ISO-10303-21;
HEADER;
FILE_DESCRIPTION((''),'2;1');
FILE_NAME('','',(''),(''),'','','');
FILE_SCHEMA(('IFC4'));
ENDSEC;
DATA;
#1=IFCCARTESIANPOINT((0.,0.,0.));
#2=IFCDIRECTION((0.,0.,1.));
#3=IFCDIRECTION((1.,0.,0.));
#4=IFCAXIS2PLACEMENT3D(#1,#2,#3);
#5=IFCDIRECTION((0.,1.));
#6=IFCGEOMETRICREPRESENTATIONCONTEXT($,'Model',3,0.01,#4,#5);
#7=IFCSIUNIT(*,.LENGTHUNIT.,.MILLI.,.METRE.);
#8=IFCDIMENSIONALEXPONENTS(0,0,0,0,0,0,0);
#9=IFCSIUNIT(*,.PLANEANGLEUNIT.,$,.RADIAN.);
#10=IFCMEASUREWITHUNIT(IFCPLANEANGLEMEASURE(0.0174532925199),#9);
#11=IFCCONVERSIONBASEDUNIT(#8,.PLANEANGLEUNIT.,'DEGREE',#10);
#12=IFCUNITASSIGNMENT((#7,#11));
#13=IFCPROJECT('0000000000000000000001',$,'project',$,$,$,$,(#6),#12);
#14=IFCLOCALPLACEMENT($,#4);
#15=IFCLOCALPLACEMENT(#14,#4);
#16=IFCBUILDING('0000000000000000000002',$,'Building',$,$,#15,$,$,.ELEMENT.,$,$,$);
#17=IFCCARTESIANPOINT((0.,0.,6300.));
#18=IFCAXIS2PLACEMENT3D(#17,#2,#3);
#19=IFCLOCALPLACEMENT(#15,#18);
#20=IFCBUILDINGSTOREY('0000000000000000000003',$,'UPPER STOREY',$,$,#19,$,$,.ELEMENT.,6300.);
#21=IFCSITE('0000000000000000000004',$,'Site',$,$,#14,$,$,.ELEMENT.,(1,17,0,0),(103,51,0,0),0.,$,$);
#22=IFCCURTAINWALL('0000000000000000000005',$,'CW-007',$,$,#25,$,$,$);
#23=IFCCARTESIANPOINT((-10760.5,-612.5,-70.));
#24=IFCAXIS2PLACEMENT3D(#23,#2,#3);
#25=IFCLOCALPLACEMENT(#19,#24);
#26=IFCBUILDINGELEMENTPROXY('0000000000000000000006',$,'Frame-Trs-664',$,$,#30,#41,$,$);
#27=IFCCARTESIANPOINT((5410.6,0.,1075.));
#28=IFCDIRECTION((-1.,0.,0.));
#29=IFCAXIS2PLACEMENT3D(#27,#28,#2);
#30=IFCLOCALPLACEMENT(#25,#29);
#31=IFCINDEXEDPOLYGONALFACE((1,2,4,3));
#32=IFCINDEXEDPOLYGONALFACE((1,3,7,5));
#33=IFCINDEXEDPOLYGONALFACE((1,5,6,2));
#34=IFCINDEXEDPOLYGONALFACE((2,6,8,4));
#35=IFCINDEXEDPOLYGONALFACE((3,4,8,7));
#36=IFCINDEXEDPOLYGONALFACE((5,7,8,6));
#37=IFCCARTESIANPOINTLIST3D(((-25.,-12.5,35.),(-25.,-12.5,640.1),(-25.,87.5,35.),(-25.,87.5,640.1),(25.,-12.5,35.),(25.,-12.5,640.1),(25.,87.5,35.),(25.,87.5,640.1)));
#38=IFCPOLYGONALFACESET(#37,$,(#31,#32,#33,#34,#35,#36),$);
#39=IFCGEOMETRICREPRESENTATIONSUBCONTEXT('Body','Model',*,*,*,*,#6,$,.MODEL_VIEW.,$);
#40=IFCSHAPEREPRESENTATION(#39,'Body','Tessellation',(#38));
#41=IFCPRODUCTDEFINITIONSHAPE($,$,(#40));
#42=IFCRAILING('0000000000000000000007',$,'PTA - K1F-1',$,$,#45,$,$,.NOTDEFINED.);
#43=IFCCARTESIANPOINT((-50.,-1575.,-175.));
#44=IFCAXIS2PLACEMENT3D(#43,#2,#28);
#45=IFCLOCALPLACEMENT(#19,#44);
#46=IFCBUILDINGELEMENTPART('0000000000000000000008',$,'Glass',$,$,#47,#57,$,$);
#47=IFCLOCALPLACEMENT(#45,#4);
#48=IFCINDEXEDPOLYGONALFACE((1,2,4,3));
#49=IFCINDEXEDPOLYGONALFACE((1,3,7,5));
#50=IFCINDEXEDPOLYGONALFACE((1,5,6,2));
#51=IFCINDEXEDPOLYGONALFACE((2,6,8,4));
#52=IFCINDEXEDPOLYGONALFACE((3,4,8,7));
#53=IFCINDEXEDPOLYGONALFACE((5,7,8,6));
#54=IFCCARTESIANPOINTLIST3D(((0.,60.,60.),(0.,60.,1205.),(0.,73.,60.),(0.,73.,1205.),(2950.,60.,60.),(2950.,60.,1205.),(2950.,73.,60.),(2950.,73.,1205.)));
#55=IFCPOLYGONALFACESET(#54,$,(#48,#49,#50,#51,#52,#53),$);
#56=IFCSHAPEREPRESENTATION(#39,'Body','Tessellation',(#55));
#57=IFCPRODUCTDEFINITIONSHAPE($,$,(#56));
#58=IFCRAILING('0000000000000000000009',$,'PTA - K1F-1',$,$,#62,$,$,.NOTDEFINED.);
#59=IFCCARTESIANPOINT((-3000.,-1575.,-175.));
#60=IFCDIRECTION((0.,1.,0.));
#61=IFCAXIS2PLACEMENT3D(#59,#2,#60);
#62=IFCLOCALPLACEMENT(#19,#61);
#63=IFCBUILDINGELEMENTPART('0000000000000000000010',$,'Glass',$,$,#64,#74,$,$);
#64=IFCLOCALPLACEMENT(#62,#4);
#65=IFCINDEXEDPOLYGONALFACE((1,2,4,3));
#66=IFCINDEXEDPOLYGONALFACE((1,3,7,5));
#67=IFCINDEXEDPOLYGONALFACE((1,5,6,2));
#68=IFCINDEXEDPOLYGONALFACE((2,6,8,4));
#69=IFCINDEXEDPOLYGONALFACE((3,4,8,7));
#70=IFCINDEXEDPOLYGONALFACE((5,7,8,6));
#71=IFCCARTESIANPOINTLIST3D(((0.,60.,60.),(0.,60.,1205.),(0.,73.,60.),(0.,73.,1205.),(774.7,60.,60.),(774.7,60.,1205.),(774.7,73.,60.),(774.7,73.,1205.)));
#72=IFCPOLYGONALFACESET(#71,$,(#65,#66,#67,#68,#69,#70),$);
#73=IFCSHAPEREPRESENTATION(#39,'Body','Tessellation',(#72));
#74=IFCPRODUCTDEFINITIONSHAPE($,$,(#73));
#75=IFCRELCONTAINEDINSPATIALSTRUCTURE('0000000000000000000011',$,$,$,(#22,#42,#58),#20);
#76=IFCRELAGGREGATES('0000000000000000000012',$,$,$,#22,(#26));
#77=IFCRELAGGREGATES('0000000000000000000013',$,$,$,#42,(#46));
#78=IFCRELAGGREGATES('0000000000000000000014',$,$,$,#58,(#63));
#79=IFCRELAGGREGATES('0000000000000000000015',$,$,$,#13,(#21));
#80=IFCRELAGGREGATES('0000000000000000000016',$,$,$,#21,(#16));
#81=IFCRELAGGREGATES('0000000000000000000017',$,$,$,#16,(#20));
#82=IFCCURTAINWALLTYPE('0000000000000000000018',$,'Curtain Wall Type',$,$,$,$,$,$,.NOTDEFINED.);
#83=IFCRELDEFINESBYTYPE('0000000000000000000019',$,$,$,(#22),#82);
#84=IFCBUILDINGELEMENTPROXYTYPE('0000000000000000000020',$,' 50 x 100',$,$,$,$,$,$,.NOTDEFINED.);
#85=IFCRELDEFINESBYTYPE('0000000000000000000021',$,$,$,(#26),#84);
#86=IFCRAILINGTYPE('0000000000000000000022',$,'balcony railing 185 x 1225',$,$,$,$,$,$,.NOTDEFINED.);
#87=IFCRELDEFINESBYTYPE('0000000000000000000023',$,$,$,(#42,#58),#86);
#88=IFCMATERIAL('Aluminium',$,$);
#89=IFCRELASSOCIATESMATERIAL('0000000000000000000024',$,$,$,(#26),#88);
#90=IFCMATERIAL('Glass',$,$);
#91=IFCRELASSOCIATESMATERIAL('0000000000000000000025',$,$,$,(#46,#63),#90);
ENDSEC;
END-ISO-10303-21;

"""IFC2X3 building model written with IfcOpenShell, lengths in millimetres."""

from ifc_helpers import new_model, entity, si_unit, converted_unit, direction, frame, origin_with_axes, place, context, subcontext, project, spatial, polyline, outline, extrude, material, type_object, element, aggregate, save


model = new_model("IFC2X3")

# Units and contexts
model_context = context("Model", 3, precision=0.01, world=origin_with_axes(), true_north=direction((0.0, 1.0)))
body_context = subcontext(model_context, "Body", "Model", "MODEL_VIEW")
ifc_project = project(units=[si_unit("LENGTHUNIT", "METRE", prefix="MILLI"), converted_unit("PLANEANGLEUNIT", "DEGREE", entity("IfcPlaneAngleMeasure", 0.0174532925199), si_unit("PLANEANGLEUNIT", "RADIAN"), dimensions=[0, 0, 0, 0, 0, 0, 0])], contexts=[model_context])

# Site, building, storey
site_placement = place(None, origin_with_axes())
site = spatial("IfcSite", under=ifc_project, at=site_placement, Name="Site", CompositionType="ELEMENT", RefLatitude=(1, 17, 0, 0), RefLongitude=(103, 51, 0, 0), RefElevation=0.0)
building_placement = place(site_placement, origin_with_axes())
building = spatial("IfcBuilding", under=site, at=building_placement, Name="Building", CompositionType="ELEMENT")
storey_placement = place(building_placement, frame((0.0, 0.0, 6300.0), z_axis=(0.0, 0.0, 1.0), x_axis=(1.0, 0.0, 0.0)))
storey = spatial("IfcBuildingStorey", under=building, at=storey_placement, Name="UPPER STOREY", CompositionType="ELEMENT", Elevation=6300.0)

# Curtain wall, building element proxy
curtain_wall_type = type_object("IfcCurtainWallType", Name="Curtain Wall Type", PredefinedType="NOTDEFINED")
curtain_wall_placement = place(storey_placement, frame((-10760.5, -612.5, -70.0), z_axis=(0.0, 0.0, 1.0), x_axis=(1.0, 0.0, 0.0)))
curtain_wall = element("IfcCurtainWall", 1, at=curtain_wall_placement, inside=storey, type_object=curtain_wall_type, Name="CW-007")
ifc_material_1 = material(Name="Aluminium")
ifc_material_2 = material(Name="Glass")
building_element_proxy_type_1 = type_object("IfcBuildingElementProxyType", Name=" 50 x 100", PredefinedType="NOTDEFINED")
proxy_1_placement = place(curtain_wall_placement, frame((5410.6, 0.0, 1075.0), z_axis=(-1.0, 0.0, 0.0), x_axis=(0.0, 0.0, 1.0)))
proxy_1 = element("IfcBuildingElementProxy", 2, at=proxy_1_placement, type_object=building_element_proxy_type_1, material=ifc_material_1, Name="Frame-Trs-664", context=body_context, shape_type="SweptSolid", body=[
    extrude(outline(polyline([(87.5, -25.0), (87.5, 25.0), (-12.5, 25.0), (-12.5, -25.0), (87.5, -25.0)])), frame((0.0, 0.0, 35.0), z_axis=(0.0, 0.0, 1.0), x_axis=(0.0, 1.0, 0.0)), (0.0, 0.0, 1.0), 605.1),
])
aggregate(curtain_wall, [proxy_1])

# Railings, building element parts
railing_type_1 = type_object("IfcRailingType", Name="balcony railing 185 x 1225", PredefinedType="NOTDEFINED")
railing_1_placement = place(storey_placement, frame((-50.0, -1575.0, -175.0), z_axis=(0.0, 0.0, 1.0), x_axis=(-1.0, 0.0, 0.0)))
railing_1 = element("IfcRailing", 3, at=railing_1_placement, inside=storey, type_object=railing_type_1, Name="PTA - K1F-1", PredefinedType="NOTDEFINED")
building_element_part_1_placement = place(railing_1_placement, origin_with_axes())
building_element_part_1 = element("IfcBuildingElementPart", 4, at=building_element_part_1_placement, material=ifc_material_2, Name="Glass", context=body_context, shape_type="SweptSolid", body=[
    extrude(outline(polyline([(60.0, 60.0), (73.0, 60.0), (73.0, 1205.0), (60.0, 1205.0), (60.0, 60.0)])), frame((0.0, 0.0, 0.0), z_axis=(1.0, 0.0, 0.0), x_axis=(0.0, 1.0, 0.0)), (0.0, 0.0, 1.0), 2950.0),
])
aggregate(railing_1, [building_element_part_1])
railing_2_placement = place(storey_placement, frame((-3000.0, -1575.0, -175.0), z_axis=(0.0, 0.0, 1.0), x_axis=(0.0, 1.0, 0.0)))
railing_2 = element("IfcRailing", 5, at=railing_2_placement, inside=storey, type_object=railing_type_1, Name="PTA - K1F-1", PredefinedType="NOTDEFINED")
building_element_part_2_placement = place(railing_2_placement, origin_with_axes())
building_element_part_2 = element("IfcBuildingElementPart", 6, at=building_element_part_2_placement, material=ifc_material_2, Name="Glass", context=body_context, shape_type="SweptSolid", body=[
    extrude(outline(polyline([(60.0, 60.0), (73.0, 60.0), (73.0, 1205.0), (60.0, 1205.0), (60.0, 60.0)])), frame((0.0, 0.0, 0.0), z_axis=(1.0, 0.0, 0.0), x_axis=(0.0, 1.0, 0.0)), (0.0, 0.0, 1.0), 774.7),
])
aggregate(railing_2, [building_element_part_2])

save(model, "model.ifc")
